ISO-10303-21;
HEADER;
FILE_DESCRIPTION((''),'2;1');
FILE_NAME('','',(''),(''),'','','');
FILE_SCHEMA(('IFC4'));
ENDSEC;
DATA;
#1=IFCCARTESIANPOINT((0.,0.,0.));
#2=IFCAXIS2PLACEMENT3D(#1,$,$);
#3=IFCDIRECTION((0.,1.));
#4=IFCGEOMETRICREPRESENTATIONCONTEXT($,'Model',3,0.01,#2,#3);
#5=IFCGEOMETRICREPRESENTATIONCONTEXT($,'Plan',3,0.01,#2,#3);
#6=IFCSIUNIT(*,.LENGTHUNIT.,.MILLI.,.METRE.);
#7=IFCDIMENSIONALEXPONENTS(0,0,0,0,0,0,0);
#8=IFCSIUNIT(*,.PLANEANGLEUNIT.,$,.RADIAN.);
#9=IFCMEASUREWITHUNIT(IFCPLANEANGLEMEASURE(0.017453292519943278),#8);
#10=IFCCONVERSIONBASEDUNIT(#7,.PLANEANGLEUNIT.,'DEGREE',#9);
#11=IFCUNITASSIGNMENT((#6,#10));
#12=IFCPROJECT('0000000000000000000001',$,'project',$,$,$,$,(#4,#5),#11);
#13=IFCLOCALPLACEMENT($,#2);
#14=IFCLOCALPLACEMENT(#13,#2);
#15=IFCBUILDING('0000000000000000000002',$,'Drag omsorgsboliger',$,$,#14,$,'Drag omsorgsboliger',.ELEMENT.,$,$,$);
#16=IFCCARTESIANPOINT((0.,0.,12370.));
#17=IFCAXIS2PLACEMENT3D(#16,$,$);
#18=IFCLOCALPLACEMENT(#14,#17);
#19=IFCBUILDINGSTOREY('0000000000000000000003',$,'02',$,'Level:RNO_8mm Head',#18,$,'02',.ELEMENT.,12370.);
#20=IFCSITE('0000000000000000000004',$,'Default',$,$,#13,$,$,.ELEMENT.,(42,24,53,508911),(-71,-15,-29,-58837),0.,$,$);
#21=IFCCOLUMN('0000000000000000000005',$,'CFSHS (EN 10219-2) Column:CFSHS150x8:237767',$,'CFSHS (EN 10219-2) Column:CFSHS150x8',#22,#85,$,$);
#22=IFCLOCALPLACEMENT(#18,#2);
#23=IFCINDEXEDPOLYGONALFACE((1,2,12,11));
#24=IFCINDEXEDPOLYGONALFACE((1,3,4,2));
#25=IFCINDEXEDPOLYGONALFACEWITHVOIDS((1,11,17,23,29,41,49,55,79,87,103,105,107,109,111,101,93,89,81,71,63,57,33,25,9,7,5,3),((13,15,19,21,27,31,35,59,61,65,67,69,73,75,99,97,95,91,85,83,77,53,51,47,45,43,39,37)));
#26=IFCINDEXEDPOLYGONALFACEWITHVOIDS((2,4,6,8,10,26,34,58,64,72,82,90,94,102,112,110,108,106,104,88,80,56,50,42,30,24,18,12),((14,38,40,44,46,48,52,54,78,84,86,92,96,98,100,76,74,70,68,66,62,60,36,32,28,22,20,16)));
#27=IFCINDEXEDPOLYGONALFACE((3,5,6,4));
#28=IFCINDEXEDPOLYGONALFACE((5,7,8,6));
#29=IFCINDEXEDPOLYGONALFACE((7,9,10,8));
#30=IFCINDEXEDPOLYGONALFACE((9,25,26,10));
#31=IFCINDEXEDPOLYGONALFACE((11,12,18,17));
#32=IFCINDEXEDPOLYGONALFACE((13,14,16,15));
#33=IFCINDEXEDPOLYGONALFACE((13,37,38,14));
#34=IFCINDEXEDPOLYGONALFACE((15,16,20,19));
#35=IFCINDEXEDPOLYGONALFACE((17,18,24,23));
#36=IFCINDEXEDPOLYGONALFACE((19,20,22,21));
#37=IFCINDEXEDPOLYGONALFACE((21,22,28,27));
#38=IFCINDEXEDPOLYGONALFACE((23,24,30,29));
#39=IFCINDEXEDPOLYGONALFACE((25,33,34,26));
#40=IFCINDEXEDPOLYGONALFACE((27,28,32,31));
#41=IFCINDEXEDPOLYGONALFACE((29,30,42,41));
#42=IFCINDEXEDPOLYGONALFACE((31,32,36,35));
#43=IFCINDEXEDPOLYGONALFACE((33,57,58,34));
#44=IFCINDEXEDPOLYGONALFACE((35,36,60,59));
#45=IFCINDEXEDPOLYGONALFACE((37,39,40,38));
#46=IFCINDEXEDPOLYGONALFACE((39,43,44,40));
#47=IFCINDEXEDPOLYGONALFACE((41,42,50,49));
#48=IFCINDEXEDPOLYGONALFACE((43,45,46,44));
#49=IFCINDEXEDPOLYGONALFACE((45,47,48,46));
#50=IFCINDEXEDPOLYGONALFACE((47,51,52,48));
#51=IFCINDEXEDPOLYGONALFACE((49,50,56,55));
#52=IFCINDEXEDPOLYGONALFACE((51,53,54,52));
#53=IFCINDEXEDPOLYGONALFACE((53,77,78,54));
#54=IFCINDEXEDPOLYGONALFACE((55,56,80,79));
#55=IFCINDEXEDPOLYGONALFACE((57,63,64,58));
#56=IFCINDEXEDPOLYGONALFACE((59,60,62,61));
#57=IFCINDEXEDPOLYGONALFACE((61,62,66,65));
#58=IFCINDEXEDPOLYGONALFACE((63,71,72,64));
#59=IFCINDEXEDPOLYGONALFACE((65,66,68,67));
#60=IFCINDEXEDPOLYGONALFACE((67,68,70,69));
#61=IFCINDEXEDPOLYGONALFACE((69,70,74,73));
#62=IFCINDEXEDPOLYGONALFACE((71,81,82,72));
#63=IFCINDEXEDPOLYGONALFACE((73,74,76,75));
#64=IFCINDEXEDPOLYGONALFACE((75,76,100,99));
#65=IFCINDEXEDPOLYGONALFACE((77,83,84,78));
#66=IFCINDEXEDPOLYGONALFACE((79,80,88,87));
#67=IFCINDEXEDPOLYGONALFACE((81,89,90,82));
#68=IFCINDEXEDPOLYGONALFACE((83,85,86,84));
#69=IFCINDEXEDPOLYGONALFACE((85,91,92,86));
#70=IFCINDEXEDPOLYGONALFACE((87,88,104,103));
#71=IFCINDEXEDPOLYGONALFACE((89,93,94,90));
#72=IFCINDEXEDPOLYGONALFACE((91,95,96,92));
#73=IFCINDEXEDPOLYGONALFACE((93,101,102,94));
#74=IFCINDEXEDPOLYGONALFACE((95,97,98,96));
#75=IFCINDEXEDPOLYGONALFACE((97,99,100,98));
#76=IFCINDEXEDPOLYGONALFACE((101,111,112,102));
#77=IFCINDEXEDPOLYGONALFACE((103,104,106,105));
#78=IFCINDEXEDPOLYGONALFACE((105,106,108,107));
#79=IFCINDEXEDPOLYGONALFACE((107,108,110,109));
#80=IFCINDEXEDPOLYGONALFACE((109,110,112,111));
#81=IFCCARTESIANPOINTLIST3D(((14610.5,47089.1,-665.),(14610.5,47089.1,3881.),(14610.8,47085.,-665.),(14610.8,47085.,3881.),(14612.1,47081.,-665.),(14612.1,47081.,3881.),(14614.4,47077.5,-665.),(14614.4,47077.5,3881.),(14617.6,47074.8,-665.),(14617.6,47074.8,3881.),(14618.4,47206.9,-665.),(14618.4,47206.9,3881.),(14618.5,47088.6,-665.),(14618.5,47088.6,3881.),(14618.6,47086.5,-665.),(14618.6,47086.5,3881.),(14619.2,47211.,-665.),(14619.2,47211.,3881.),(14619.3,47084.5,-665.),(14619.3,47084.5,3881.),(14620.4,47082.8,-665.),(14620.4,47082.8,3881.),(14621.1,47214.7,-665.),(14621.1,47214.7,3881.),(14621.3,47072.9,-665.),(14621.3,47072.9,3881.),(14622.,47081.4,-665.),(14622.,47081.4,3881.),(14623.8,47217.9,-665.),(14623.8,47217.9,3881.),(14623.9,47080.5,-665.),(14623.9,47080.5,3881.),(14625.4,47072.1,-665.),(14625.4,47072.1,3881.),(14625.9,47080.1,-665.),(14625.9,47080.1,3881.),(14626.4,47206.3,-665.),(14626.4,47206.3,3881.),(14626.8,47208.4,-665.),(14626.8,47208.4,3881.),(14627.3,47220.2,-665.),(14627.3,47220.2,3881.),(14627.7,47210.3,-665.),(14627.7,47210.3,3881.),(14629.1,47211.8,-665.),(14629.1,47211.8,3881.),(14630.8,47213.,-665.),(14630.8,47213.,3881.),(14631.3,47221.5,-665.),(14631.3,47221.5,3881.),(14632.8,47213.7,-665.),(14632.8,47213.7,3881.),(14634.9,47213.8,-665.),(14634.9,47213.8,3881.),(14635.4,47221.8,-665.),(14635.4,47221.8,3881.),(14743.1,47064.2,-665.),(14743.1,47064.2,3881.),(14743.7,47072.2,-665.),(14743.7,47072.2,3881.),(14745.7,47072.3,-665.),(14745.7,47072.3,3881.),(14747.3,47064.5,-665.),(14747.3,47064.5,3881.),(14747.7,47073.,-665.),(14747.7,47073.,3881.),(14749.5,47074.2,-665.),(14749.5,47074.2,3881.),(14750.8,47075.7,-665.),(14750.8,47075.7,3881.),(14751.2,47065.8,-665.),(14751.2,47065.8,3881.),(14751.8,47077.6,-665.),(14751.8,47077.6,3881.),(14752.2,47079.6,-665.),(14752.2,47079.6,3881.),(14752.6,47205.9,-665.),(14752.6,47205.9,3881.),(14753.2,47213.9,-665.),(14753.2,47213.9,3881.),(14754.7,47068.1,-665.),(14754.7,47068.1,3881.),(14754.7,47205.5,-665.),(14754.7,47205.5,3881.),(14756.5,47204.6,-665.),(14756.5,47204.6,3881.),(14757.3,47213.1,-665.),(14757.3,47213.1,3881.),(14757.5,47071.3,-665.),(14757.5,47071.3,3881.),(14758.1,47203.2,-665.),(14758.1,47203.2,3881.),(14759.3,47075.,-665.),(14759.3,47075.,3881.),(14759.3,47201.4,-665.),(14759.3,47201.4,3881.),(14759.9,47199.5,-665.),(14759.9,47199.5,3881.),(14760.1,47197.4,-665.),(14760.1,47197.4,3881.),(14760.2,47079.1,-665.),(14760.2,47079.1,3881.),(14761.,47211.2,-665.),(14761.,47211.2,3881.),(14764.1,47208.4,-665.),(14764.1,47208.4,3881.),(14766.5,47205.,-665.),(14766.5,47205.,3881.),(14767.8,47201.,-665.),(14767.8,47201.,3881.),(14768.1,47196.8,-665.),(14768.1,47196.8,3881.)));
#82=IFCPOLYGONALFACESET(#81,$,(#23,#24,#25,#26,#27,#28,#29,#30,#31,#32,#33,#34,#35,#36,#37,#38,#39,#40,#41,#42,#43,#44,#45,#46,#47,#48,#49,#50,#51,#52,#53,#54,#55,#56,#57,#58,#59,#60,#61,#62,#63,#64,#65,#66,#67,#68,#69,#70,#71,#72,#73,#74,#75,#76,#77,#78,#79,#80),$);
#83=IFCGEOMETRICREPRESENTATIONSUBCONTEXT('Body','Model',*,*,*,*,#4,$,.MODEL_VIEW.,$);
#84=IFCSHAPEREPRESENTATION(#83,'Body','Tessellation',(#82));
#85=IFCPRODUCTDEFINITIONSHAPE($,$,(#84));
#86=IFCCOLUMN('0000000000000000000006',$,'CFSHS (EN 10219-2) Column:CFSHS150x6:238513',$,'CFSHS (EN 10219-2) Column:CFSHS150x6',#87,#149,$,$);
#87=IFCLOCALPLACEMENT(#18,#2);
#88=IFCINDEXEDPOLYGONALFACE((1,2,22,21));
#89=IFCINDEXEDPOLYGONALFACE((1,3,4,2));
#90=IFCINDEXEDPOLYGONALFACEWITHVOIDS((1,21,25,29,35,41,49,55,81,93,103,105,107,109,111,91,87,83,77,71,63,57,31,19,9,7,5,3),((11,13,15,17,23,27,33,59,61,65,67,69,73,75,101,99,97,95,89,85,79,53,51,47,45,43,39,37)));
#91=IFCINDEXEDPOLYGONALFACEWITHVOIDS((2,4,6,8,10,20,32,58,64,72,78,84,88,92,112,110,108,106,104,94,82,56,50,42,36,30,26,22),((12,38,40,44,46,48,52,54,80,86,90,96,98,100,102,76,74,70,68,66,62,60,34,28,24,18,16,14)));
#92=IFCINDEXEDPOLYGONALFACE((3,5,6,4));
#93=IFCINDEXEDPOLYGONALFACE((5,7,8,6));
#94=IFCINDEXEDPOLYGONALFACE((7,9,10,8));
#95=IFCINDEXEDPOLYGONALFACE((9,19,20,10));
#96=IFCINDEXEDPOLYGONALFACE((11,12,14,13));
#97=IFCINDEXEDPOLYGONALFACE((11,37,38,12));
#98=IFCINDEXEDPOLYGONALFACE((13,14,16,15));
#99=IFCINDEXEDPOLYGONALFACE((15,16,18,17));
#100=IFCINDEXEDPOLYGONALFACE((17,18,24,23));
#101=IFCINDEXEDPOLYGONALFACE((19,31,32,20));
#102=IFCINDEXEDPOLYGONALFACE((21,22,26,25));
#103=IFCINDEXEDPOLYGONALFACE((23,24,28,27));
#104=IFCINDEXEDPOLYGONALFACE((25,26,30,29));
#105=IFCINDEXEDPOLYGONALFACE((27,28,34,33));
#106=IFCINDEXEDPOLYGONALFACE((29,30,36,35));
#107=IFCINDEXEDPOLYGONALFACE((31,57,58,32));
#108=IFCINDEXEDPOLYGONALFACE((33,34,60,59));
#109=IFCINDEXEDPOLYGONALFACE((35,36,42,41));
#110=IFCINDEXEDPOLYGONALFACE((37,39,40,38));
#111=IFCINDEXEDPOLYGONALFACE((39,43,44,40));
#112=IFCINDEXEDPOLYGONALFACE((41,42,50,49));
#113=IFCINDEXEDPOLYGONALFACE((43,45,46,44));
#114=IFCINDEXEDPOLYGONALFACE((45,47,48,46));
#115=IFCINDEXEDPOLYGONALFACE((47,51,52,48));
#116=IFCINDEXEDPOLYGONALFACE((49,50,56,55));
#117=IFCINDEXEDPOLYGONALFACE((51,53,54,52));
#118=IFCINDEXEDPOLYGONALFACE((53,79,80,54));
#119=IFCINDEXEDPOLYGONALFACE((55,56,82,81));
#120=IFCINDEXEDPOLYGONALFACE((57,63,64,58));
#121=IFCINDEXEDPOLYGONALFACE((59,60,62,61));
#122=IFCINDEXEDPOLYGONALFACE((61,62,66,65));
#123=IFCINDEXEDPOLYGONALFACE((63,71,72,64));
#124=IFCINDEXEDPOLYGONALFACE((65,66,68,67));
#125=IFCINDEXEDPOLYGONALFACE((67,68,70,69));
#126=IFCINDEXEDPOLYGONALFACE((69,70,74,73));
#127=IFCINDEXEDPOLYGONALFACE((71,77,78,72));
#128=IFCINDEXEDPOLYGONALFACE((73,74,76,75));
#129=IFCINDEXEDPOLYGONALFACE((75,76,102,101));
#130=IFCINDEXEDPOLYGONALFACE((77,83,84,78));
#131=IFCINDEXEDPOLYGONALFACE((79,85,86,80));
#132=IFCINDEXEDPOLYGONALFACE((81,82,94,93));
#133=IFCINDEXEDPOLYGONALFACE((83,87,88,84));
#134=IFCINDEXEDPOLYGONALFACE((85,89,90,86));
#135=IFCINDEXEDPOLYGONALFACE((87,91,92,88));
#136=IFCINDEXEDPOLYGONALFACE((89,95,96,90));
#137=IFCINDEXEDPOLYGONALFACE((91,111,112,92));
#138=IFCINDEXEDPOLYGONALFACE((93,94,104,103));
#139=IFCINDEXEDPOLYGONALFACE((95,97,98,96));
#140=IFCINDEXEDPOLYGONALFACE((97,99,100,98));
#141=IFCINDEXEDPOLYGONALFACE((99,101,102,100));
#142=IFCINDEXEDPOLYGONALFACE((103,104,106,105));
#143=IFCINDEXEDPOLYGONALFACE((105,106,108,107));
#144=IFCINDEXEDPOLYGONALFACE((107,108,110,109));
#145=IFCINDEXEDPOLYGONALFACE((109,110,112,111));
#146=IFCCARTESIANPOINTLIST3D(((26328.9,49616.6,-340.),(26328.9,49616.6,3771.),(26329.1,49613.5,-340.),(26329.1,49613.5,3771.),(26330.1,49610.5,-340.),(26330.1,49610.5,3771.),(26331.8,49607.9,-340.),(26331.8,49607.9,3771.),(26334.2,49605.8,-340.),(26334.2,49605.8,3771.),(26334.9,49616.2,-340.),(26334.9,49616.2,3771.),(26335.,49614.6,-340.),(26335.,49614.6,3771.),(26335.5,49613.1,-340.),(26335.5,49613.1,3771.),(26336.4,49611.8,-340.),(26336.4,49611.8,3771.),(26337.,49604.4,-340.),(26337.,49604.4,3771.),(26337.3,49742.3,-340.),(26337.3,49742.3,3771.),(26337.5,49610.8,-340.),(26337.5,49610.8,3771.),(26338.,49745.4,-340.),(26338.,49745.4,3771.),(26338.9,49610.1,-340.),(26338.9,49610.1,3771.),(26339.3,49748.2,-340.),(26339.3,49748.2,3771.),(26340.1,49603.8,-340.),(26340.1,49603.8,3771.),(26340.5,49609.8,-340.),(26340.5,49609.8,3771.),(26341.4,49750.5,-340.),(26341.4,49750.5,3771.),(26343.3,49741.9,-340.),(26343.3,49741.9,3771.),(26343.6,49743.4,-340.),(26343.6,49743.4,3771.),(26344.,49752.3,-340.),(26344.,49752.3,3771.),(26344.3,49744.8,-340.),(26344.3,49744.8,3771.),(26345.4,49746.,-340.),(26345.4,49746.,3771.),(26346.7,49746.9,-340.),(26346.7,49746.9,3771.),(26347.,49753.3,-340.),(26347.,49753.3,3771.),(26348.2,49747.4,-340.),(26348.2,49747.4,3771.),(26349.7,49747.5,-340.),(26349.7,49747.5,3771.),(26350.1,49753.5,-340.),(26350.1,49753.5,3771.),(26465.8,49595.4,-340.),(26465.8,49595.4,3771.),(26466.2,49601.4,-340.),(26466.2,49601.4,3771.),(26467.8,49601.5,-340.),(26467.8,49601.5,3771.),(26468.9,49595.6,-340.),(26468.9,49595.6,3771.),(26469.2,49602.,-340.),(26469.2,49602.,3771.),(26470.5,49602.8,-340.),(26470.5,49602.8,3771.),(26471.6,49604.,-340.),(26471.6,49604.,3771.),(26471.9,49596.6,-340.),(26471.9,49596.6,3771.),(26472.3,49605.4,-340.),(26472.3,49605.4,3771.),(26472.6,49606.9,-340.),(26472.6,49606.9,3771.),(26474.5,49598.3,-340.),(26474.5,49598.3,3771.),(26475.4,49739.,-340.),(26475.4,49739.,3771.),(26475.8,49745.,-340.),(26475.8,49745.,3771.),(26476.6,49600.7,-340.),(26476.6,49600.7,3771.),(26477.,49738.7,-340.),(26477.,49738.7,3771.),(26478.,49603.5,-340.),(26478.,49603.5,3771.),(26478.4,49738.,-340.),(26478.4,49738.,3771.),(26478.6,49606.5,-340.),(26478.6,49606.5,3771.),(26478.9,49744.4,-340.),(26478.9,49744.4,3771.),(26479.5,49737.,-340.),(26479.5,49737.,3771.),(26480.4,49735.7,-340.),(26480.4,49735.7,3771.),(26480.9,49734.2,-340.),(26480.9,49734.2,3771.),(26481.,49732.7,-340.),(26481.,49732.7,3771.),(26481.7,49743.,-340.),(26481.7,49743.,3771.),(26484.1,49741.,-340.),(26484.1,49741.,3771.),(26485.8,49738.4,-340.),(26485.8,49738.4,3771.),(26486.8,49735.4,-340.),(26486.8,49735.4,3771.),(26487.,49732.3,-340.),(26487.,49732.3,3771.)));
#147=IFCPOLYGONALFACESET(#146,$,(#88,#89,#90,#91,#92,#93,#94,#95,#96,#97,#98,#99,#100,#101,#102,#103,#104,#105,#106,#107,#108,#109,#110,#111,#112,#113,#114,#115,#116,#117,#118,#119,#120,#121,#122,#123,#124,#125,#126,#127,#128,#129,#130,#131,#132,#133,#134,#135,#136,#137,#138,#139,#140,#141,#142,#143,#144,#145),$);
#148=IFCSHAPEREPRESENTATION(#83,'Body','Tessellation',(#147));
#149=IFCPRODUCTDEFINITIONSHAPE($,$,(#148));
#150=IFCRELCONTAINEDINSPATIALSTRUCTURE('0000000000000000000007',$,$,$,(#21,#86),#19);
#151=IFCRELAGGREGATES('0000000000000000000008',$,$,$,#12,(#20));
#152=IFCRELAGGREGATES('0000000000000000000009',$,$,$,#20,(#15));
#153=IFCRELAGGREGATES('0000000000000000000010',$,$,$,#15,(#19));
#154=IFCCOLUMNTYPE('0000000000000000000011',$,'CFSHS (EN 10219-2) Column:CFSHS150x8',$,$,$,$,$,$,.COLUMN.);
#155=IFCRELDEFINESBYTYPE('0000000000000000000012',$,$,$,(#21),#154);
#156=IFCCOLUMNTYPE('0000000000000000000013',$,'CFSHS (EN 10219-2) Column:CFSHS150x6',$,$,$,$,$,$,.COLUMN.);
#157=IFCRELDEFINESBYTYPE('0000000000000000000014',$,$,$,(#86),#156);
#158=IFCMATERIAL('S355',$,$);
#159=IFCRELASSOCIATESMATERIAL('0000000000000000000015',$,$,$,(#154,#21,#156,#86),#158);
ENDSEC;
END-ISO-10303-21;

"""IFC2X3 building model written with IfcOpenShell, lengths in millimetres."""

from ifc_helpers import new_model, entity, si_unit, converted_unit, direction, frame, frame_2d, origin, place, context, subcontext, project, spatial, polyline, circle_curve, parameter, trimmed, segment, composite_curve, outline, extrude, source, transform, mapped, material, type_object, type_shapes, element, save


model = new_model("IFC2X3")

# Units and contexts
model_context = context("Model", 3, precision=0.01, world=origin(), true_north=direction((0.0, 1.0)))
plan_context = context("Plan", 3, precision=0.01, world=origin(), true_north=direction((0.0, 1.0)))
body_context = subcontext(model_context, "Body", "Model", "MODEL_VIEW")
ifc_project = project(units=[si_unit("LENGTHUNIT", "METRE", prefix="MILLI"), converted_unit("PLANEANGLEUNIT", "DEGREE", entity("IfcPlaneAngleMeasure", 0.017453292519943278), si_unit("PLANEANGLEUNIT", "RADIAN"), dimensions=[0, 0, 0, 0, 0, 0, 0])], contexts=[model_context, plan_context])

# Site, building, storey
site_placement = place(None, origin())
site = spatial("IfcSite", under=ifc_project, at=site_placement, Name="Default", CompositionType="ELEMENT", RefLatitude=(42, 24, 53, 508911), RefLongitude=(-71, -15, -29, -58837), RefElevation=0.0)
building_placement = place(site_placement, origin())
building = spatial("IfcBuilding", under=site, at=building_placement, Name="Drag omsorgsboliger", LongName="Drag omsorgsboliger", CompositionType="ELEMENT")
storey_placement = place(building_placement, frame((0.0, 0.0, 12370.0)))
storey = spatial("IfcBuildingStorey", under=building, at=storey_placement, Name="02", ObjectType="Level:RNO_8mm Head", LongName="02", CompositionType="ELEMENT", Elevation=12370.0)

# Columns
ifc_material = material(Name="S355")
column_type_1 = type_object("IfcColumnType", Name="CFSHS (EN 10219-2) Column:CFSHS150x8", PredefinedType="COLUMN", material=ifc_material)
shared_shape_1 = source(origin(), body_context, "Body", "SweptSolid", [
    extrude(outline(composite_curve([segment(polyline([(-59.0, -75.0), (59.0, -75.0)]), True, "CONTINUOUS"), segment(trimmed(circle_curve(frame_2d((59.0, -59.0), x_axis=(-1.0, 0.0)), 16.0), [parameter(90.0)], [parameter(180.0)], True, "PARAMETER"), True, "CONTINUOUS"), segment(polyline([(75.0, -59.0), (75.0, 59.0)]), True, "CONTINUOUS"), segment(trimmed(circle_curve(frame_2d((59.0, 59.0), x_axis=(-1.0, 0.0)), 16.0), [parameter(180.0)], [parameter(270.0)], True, "PARAMETER"), True, "CONTINUOUS"), segment(polyline([(59.0, 75.0), (-59.0, 75.0)]), True, "CONTINUOUS"), segment(trimmed(circle_curve(frame_2d((-59.0, 59.0), x_axis=(-1.0, 0.0)), 16.0), [parameter(270.0)], [parameter(360.0)], True, "PARAMETER"), True, "CONTINUOUS"), segment(polyline([(-75.0, 59.0), (-75.0, -59.0)]), True, "CONTINUOUS"), segment(trimmed(circle_curve(frame_2d((-59.0, -59.0), x_axis=(-1.0, 0.0)), 16.0), [parameter(360.0)], [parameter(90.0)], True, "PARAMETER"), True, "CONTINUOUS")], self_intersect=False), holes=[composite_curve([segment(trimmed(circle_curve(frame_2d((-59.0, -59.0), x_axis=(-1.0, 0.0)), 8.0), [parameter(360.0)], [parameter(90.0)], True, "PARAMETER"), False, "CONTINUOUS"), segment(polyline([(-67.0, -59.0), (-67.0, 59.0)]), True, "CONTINUOUS"), segment(trimmed(circle_curve(frame_2d((-59.0, 59.0), x_axis=(-1.0, 0.0)), 8.0), [parameter(270.0)], [parameter(360.0)], True, "PARAMETER"), False, "CONTINUOUS"), segment(polyline([(-59.0, 67.0), (59.0, 67.0)]), True, "CONTINUOUS"), segment(trimmed(circle_curve(frame_2d((59.0, 59.0), x_axis=(-1.0, 0.0)), 8.0), [parameter(180.0)], [parameter(270.0)], True, "PARAMETER"), False, "CONTINUOUS"), segment(polyline([(67.0, 59.0), (67.0, -59.0)]), True, "CONTINUOUS"), segment(trimmed(circle_curve(frame_2d((59.0, -59.0), x_axis=(-1.0, 0.0)), 8.0), [parameter(90.0)], [parameter(180.0)], True, "PARAMETER"), False, "CONTINUOUS"), segment(polyline([(59.0, -67.0), (-59.0, -67.0)]), True, "CONTINUOUS")], self_intersect=False)]), frame((14689.3, 47143.0, 11705.0), z_axis=(0.0, 0.0, 1.0), x_axis=(-0.997758, 0.066923, 0.0)), (0.0, 0.0, 1.0), 4546.0),
])
type_shapes(column_type_1, [shared_shape_1])
column_1_placement = place(storey_placement, frame((0.0, 0.0, -12370.0)))
element("IfcColumn", 1, at=column_1_placement, inside=storey, type_object=column_type_1, material=ifc_material, Name="CFSHS (EN 10219-2) Column:CFSHS150x8:237767", ObjectType="CFSHS (EN 10219-2) Column:CFSHS150x8", context=body_context, shape_type="MappedRepresentation", body=[
    mapped(shared_shape_1, transform((0.0, 0.0, 0.0), scale=1.0)),
])
column_type_2 = type_object("IfcColumnType", Name="CFSHS (EN 10219-2) Column:CFSHS150x6", PredefinedType="COLUMN", material=ifc_material)
shared_shape_2 = source(origin(), body_context, "Body", "SweptSolid", [
    extrude(outline(composite_curve([segment(polyline([(-63.0, -75.0), (63.0, -75.0)]), True, "CONTINUOUS"), segment(trimmed(circle_curve(frame_2d((63.0, -63.0), x_axis=(-1.0, 0.0)), 12.0), [parameter(90.0)], [parameter(180.0)], True, "PARAMETER"), True, "CONTINUOUS"), segment(polyline([(75.0, -63.0), (75.0, 63.0)]), True, "CONTINUOUS"), segment(trimmed(circle_curve(frame_2d((63.0, 63.0), x_axis=(-1.0, 0.0)), 12.0), [parameter(180.0)], [parameter(270.0)], True, "PARAMETER"), True, "CONTINUOUS"), segment(polyline([(63.0, 75.0), (-63.0, 75.0)]), True, "CONTINUOUS"), segment(trimmed(circle_curve(frame_2d((-63.0, 63.0), x_axis=(-1.0, 0.0)), 12.0), [parameter(270.0)], [parameter(360.0)], True, "PARAMETER"), True, "CONTINUOUS"), segment(polyline([(-75.0, 63.0), (-75.0, -63.0)]), True, "CONTINUOUS"), segment(trimmed(circle_curve(frame_2d((-63.0, -63.0), x_axis=(-1.0, 0.0)), 12.0), [parameter(360.0)], [parameter(90.0)], True, "PARAMETER"), True, "CONTINUOUS")], self_intersect=False), holes=[composite_curve([segment(trimmed(circle_curve(frame_2d((-63.0, -63.0), x_axis=(-1.0, 0.0)), 6.0), [parameter(360.0)], [parameter(90.0)], True, "PARAMETER"), False, "CONTINUOUS"), segment(polyline([(-69.0, -63.0), (-69.0, 63.0)]), True, "CONTINUOUS"), segment(trimmed(circle_curve(frame_2d((-63.0, 63.0), x_axis=(-1.0, 0.0)), 6.0), [parameter(270.0)], [parameter(360.0)], True, "PARAMETER"), False, "CONTINUOUS"), segment(polyline([(-63.0, 69.0), (63.0, 69.0)]), True, "CONTINUOUS"), segment(trimmed(circle_curve(frame_2d((63.0, 63.0), x_axis=(-1.0, 0.0)), 6.0), [parameter(180.0)], [parameter(270.0)], True, "PARAMETER"), False, "CONTINUOUS"), segment(polyline([(69.0, 63.0), (69.0, -63.0)]), True, "CONTINUOUS"), segment(trimmed(circle_curve(frame_2d((63.0, -63.0), x_axis=(-1.0, 0.0)), 6.0), [parameter(90.0)], [parameter(180.0)], True, "PARAMETER"), False, "CONTINUOUS"), segment(polyline([(63.0, -69.0), (-63.0, -69.0)]), True, "CONTINUOUS")], self_intersect=False)]), frame((26408.0, 49674.4, 12030.0), z_axis=(0.0, 0.0, 1.0), x_axis=(-0.997758, 0.066923, 0.0)), (0.0, 0.0, 1.0), 4111.0),
])
type_shapes(column_type_2, [shared_shape_2])
column_2_placement = place(storey_placement, frame((0.0, 0.0, -12370.0)))
element("IfcColumn", 2, at=column_2_placement, inside=storey, type_object=column_type_2, material=ifc_material, Name="CFSHS (EN 10219-2) Column:CFSHS150x6:238513", ObjectType="CFSHS (EN 10219-2) Column:CFSHS150x6", context=body_context, shape_type="MappedRepresentation", body=[
    mapped(shared_shape_2, transform((0.0, 0.0, 0.0), scale=1.0)),
])

save(model, "model.ifc")
